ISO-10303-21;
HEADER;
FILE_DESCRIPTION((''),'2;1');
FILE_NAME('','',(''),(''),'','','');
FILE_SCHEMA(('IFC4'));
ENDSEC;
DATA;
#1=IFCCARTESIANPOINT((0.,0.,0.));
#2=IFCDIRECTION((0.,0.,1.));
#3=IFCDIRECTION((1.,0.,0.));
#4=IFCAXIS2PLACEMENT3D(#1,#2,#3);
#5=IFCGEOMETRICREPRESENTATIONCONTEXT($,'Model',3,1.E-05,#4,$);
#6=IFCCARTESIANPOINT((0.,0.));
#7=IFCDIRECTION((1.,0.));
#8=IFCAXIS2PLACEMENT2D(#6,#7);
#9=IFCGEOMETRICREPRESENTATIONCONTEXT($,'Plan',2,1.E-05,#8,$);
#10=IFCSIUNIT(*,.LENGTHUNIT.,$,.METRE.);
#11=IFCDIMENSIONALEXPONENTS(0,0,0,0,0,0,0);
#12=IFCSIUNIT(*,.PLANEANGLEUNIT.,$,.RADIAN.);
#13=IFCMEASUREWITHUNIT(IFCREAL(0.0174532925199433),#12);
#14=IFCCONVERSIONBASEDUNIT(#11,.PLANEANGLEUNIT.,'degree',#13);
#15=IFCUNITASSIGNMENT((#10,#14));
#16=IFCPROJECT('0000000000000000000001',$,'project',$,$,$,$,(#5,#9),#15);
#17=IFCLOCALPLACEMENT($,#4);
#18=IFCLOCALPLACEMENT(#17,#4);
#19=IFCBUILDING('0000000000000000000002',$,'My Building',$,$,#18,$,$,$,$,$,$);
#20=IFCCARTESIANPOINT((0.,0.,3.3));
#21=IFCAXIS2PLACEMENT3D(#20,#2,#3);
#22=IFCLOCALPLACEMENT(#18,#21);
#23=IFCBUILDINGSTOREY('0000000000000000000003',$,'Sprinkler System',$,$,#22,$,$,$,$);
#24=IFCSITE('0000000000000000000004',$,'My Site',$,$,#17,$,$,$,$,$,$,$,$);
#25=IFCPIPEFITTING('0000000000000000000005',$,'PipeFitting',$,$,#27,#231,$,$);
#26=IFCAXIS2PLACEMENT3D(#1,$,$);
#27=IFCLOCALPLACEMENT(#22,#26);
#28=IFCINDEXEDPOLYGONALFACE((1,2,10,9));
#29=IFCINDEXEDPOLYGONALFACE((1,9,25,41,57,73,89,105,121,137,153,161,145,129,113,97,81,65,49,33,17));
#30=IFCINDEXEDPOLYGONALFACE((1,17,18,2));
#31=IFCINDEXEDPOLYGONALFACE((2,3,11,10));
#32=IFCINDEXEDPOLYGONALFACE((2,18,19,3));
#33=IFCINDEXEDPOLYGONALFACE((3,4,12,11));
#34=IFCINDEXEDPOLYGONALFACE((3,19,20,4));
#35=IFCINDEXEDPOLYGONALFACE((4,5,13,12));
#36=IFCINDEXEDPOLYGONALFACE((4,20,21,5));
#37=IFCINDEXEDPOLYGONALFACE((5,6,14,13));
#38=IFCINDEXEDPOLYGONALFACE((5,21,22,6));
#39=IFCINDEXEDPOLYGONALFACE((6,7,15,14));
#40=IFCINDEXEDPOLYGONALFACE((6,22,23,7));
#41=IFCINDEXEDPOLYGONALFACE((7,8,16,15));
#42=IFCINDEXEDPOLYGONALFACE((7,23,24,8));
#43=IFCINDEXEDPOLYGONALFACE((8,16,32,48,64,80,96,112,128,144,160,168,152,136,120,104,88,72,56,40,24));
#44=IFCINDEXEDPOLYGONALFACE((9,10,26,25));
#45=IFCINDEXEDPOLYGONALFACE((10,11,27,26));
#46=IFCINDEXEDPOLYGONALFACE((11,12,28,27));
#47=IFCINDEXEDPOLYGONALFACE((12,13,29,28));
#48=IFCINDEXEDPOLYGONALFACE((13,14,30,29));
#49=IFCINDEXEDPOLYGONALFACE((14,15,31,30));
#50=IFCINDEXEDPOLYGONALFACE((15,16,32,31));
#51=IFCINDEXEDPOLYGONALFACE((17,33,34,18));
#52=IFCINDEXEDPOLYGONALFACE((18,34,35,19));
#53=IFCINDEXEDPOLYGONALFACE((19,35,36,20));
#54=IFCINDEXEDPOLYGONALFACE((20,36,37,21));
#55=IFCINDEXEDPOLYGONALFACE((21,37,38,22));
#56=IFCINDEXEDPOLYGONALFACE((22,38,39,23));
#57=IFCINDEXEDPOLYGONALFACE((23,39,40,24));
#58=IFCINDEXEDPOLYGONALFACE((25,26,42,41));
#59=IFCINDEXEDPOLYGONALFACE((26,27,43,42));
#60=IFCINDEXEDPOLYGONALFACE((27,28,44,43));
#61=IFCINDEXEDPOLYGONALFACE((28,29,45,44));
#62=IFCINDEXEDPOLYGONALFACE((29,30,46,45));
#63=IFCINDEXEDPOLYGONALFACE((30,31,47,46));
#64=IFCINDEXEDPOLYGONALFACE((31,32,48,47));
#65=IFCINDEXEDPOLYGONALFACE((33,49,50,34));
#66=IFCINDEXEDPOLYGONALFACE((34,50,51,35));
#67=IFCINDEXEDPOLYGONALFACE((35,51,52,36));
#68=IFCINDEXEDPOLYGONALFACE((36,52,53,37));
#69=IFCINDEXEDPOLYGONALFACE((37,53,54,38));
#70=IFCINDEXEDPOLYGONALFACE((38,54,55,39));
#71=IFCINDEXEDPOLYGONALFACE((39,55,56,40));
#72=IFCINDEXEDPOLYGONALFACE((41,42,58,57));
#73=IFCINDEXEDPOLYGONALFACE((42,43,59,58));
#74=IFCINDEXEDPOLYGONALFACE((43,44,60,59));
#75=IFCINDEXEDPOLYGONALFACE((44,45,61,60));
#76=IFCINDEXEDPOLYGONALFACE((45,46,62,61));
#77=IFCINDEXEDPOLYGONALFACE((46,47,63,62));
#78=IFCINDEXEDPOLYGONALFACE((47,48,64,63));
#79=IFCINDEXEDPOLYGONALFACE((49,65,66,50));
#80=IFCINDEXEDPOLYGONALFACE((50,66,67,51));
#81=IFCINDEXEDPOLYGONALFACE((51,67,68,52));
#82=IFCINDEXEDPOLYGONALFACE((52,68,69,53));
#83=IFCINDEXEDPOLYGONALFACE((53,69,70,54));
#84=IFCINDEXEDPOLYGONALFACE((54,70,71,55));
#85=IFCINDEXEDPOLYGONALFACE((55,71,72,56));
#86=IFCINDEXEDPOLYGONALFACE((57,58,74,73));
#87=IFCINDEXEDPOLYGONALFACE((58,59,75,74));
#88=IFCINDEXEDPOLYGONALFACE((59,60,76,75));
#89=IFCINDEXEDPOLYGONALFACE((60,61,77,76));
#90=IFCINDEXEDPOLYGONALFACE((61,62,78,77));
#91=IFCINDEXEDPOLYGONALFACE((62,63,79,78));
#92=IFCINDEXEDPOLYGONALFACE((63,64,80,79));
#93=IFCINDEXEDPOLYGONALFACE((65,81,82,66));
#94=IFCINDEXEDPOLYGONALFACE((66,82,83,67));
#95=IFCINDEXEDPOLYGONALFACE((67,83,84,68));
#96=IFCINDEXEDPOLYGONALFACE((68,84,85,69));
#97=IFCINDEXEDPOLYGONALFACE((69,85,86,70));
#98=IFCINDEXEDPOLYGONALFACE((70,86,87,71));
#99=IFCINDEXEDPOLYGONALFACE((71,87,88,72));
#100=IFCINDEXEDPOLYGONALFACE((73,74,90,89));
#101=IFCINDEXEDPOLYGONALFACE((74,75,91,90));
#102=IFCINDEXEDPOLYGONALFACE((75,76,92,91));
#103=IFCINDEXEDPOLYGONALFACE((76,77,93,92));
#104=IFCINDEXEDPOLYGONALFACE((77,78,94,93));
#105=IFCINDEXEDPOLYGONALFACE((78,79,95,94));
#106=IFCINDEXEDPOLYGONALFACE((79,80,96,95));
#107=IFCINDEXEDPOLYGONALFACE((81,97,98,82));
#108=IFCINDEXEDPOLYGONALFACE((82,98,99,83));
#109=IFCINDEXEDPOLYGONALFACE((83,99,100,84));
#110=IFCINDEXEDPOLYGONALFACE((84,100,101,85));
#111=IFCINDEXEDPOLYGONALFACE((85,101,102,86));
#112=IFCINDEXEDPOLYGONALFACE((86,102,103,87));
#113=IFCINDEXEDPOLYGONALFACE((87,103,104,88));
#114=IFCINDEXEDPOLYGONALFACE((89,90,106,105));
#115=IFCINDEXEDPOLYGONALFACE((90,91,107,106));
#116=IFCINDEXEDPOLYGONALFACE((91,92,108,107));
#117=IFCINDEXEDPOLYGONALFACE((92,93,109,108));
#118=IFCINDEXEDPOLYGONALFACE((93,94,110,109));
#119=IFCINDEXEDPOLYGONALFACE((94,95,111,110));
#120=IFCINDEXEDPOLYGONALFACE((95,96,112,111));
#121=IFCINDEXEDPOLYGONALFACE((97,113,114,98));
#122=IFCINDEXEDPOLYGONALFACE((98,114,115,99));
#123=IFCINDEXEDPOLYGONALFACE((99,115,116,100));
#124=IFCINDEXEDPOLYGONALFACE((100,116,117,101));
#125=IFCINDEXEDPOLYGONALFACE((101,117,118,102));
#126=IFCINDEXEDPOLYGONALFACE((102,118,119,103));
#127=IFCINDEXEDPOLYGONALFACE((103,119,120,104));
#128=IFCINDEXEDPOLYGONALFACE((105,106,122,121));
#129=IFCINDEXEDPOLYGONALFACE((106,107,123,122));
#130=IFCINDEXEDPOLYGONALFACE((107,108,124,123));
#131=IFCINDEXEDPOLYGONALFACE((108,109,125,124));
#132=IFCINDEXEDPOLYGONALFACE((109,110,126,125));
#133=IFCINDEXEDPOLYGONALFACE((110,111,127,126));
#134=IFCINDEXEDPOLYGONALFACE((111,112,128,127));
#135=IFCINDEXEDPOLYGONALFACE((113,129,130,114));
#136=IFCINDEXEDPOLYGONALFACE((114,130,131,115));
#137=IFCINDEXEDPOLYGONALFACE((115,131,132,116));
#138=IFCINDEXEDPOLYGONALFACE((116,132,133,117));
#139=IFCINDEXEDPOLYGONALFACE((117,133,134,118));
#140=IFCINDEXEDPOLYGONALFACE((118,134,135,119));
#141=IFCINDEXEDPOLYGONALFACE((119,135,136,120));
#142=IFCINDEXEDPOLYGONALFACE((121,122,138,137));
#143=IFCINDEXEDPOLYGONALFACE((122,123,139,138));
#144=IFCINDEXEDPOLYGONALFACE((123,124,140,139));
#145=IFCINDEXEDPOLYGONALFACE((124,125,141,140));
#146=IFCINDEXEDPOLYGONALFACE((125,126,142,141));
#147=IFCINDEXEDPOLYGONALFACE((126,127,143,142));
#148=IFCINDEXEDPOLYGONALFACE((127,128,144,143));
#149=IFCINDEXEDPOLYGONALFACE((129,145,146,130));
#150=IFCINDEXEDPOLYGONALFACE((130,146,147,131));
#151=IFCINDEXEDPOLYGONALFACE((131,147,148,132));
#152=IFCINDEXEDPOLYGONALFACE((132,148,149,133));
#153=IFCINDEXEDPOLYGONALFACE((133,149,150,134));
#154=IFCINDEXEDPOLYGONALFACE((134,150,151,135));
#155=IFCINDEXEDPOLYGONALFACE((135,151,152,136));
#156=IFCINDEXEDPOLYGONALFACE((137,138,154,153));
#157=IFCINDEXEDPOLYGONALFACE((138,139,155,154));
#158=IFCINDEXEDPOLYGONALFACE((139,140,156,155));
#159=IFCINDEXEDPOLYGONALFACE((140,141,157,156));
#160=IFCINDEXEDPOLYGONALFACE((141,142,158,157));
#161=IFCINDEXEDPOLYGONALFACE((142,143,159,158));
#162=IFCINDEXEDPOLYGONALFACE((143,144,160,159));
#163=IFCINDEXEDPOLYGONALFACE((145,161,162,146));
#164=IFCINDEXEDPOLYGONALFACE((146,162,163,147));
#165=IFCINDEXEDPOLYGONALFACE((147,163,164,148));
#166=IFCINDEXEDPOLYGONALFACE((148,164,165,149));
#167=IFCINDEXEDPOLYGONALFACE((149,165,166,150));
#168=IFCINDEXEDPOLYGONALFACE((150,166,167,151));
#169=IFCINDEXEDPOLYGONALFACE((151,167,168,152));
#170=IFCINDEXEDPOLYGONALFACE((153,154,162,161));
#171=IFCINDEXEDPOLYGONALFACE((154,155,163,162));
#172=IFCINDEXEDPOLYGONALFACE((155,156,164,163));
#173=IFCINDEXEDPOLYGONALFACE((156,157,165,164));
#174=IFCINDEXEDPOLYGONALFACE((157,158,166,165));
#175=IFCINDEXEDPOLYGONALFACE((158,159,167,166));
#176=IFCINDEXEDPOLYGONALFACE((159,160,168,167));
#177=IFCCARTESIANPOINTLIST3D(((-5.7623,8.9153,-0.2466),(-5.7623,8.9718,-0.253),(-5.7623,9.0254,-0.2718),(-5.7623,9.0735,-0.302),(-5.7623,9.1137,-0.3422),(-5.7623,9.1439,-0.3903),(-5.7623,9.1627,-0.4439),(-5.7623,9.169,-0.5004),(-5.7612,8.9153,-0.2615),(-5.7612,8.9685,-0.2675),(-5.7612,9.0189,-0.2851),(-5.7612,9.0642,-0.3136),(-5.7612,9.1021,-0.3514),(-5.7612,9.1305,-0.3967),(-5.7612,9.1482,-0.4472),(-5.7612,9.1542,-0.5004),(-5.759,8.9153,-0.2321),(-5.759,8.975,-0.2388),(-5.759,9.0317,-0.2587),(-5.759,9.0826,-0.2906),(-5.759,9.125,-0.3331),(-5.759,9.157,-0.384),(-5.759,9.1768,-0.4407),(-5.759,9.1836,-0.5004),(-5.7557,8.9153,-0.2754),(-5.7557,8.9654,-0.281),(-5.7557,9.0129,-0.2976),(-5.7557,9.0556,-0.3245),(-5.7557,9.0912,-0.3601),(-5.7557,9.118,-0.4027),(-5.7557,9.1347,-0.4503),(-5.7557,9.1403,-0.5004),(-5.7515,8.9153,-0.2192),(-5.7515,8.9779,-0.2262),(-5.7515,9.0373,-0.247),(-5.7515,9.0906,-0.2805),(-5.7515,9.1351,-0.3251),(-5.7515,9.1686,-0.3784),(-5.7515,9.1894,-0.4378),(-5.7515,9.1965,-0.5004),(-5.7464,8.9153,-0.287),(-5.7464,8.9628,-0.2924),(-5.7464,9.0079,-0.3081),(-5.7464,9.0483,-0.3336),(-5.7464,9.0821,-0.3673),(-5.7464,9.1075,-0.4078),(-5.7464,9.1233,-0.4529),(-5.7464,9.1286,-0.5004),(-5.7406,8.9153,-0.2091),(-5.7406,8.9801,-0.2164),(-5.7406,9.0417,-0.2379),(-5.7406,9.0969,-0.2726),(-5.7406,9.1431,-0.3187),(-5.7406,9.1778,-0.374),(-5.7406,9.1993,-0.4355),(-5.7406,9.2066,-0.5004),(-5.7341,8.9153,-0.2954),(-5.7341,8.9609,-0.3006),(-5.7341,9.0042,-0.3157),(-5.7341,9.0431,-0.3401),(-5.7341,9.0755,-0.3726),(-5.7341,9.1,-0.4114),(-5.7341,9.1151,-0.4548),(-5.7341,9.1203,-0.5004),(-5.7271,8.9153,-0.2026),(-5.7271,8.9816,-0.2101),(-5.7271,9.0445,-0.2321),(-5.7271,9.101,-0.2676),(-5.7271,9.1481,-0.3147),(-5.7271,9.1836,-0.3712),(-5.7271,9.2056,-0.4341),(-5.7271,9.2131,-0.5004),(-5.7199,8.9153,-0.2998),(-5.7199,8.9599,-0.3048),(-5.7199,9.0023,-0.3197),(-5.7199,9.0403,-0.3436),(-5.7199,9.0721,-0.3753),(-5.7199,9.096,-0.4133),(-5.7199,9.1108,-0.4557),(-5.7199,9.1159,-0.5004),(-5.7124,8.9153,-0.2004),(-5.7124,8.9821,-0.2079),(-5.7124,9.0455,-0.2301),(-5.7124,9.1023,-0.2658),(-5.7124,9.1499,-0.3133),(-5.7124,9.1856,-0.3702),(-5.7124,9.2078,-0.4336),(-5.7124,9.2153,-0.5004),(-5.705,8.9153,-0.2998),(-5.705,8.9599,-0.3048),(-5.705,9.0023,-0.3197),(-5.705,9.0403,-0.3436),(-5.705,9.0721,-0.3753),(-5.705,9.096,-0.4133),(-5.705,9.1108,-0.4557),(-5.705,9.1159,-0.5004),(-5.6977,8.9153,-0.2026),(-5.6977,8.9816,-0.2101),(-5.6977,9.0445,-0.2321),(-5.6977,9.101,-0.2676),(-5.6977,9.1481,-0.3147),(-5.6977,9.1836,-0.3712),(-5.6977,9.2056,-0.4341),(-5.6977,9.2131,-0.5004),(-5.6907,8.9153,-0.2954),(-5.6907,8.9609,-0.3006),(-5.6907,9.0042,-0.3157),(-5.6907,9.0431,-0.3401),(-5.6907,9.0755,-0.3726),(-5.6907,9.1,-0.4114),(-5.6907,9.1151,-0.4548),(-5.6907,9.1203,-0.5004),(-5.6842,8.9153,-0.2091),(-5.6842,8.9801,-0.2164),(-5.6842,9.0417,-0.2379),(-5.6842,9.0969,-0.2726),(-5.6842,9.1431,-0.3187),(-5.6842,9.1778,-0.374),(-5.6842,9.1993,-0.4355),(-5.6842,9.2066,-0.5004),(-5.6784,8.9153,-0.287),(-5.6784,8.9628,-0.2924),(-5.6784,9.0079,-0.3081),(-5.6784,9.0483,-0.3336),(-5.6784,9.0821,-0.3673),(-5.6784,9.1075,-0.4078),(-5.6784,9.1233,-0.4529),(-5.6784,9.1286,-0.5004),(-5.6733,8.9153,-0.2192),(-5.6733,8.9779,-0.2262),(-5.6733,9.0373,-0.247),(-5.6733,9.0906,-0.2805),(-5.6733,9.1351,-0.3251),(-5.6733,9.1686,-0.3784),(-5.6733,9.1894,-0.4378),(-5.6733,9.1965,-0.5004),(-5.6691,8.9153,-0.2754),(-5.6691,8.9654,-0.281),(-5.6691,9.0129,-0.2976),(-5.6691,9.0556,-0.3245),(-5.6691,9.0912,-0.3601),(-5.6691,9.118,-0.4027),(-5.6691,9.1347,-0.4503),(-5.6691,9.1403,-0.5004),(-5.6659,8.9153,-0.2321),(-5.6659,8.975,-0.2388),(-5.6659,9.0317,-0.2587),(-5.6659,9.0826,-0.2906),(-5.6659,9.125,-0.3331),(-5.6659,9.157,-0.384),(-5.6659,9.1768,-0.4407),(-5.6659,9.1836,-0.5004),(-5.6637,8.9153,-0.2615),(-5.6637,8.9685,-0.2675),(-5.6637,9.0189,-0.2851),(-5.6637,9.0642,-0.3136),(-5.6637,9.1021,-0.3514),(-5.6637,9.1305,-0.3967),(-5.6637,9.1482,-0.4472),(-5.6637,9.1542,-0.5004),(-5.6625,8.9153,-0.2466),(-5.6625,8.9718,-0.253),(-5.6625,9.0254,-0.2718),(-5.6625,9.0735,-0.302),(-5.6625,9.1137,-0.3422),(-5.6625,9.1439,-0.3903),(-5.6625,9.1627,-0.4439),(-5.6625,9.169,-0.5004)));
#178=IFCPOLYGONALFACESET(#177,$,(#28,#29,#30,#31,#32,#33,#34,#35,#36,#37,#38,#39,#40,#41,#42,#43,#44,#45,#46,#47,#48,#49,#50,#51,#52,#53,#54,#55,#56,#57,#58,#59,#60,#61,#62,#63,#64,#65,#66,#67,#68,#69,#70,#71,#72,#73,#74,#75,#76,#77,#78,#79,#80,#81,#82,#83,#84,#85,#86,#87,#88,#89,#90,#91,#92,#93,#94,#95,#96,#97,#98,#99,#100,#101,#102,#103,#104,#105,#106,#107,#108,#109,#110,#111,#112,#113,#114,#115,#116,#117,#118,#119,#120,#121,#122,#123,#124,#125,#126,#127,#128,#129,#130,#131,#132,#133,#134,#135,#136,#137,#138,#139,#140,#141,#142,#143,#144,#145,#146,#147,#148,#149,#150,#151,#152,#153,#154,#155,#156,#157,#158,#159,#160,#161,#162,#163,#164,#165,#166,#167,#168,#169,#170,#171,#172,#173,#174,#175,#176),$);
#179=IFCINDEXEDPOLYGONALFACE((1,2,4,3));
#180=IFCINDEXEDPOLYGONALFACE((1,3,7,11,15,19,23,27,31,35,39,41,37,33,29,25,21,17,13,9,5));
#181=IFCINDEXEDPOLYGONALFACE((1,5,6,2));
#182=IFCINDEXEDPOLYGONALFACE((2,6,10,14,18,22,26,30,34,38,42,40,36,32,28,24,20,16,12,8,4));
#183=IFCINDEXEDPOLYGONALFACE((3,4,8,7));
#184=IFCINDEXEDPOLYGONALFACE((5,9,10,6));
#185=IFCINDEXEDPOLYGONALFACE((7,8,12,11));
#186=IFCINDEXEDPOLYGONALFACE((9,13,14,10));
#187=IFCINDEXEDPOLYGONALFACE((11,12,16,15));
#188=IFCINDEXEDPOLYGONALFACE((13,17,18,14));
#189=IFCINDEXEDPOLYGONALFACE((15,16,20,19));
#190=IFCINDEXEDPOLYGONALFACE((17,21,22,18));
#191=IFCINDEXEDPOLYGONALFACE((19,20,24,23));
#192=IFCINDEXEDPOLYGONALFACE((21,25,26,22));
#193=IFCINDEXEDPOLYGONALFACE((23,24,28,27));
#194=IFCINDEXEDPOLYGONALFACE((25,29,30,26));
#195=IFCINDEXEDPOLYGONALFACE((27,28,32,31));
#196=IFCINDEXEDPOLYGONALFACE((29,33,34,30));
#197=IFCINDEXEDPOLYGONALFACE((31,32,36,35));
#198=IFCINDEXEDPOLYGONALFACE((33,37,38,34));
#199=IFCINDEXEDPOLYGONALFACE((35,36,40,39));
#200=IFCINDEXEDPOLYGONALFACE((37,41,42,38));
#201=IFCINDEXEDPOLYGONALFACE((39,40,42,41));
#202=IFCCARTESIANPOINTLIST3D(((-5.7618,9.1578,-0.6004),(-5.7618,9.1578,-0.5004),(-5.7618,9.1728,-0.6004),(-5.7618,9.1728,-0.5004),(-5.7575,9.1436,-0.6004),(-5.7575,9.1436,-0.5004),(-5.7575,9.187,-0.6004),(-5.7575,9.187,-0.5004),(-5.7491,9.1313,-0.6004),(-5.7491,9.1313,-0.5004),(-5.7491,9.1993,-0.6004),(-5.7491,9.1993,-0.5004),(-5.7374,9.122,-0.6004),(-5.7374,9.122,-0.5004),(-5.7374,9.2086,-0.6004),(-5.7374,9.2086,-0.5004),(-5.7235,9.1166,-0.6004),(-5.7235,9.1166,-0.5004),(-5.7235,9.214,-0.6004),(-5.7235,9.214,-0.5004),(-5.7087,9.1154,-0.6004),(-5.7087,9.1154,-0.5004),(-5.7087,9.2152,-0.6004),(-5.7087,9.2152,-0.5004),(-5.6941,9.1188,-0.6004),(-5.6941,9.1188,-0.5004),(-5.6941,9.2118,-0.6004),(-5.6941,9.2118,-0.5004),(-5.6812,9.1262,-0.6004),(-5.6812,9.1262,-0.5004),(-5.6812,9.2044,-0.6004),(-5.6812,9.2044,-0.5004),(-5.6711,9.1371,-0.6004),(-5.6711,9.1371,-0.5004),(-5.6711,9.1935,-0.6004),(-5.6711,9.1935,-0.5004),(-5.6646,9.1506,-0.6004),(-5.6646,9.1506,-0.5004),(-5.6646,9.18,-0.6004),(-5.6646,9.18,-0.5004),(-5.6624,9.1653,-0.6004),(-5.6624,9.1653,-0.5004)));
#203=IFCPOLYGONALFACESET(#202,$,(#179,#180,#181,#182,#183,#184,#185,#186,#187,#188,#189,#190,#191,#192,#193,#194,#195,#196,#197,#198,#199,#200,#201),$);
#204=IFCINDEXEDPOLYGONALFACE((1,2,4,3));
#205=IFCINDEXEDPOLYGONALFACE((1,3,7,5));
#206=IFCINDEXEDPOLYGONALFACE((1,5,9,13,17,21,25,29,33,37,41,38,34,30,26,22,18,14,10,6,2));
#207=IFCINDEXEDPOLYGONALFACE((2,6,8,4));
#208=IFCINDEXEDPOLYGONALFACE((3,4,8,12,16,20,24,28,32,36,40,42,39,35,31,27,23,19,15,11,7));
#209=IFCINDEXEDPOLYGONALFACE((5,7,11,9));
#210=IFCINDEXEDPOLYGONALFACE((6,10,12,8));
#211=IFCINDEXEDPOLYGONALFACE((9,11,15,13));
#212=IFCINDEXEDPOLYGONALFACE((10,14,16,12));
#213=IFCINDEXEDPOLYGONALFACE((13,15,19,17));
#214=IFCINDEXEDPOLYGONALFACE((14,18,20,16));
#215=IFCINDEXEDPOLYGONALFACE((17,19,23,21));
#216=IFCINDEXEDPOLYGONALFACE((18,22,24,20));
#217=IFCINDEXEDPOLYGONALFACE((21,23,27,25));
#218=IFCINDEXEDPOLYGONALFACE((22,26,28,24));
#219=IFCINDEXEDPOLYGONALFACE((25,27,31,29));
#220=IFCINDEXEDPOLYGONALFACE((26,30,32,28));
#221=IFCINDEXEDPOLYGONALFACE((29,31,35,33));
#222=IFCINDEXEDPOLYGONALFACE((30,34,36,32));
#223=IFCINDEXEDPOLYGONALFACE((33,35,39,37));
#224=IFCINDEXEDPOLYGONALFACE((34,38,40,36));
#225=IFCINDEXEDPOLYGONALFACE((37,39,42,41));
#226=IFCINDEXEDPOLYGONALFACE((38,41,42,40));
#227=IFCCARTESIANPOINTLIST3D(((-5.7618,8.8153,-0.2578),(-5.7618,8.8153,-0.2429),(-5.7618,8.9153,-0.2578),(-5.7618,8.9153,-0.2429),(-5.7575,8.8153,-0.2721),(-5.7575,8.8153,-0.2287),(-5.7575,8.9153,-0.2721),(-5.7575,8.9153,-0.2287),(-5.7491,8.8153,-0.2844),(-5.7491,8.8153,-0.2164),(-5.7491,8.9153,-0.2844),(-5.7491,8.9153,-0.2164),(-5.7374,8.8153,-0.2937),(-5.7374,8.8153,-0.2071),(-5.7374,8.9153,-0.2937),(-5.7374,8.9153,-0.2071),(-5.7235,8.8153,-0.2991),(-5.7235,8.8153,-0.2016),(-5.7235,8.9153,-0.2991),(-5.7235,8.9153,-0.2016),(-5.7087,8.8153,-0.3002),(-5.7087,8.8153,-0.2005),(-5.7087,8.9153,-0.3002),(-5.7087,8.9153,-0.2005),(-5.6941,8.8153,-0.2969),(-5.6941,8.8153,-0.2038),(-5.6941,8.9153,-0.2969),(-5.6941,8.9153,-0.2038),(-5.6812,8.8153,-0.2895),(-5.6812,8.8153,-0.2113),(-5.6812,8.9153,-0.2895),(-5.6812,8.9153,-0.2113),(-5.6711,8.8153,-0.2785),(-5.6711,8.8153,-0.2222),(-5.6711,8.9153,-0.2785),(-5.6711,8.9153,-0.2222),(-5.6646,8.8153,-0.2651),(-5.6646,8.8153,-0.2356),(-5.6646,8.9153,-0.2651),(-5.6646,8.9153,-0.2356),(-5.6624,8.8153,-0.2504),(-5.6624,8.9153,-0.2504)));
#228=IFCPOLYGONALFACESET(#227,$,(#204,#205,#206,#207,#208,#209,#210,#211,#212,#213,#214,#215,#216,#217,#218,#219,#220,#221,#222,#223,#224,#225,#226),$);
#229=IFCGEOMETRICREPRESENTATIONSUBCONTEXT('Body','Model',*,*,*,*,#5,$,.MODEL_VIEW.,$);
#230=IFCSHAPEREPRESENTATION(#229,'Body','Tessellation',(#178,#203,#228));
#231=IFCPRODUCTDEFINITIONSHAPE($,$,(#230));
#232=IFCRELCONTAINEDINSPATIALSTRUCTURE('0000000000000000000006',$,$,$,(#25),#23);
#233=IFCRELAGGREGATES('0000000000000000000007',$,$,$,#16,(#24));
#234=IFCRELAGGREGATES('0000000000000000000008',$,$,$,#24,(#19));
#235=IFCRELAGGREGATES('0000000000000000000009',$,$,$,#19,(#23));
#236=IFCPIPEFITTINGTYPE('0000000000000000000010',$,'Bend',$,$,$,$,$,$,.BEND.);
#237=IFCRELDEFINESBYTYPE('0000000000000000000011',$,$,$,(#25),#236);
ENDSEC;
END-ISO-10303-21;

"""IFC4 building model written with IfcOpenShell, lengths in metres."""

from ifc_helpers import new_model, entity, si_unit, converted_unit, frame, origin_with_axes, origin_2d_with_axis, place, context, subcontext, project, spatial, circle, extrude, source, transform, mapped, type_object, type_shapes, element, save


model = new_model("IFC4")

# Units and contexts
model_context = context("Model", 3, precision=1e-05, world=origin_with_axes())
plan_context = context("Plan", 2, precision=1e-05, world=origin_2d_with_axis())
body_context = subcontext(model_context, "Body", "Model", "MODEL_VIEW")
ifc_project = project(units=[si_unit("LENGTHUNIT", "METRE"), converted_unit("PLANEANGLEUNIT", "degree", entity("IfcReal", 0.0174532925199433), si_unit("PLANEANGLEUNIT", "RADIAN"), dimensions=[0, 0, 0, 0, 0, 0, 0])], contexts=[model_context, plan_context])

# Site, building, storey
site_placement = place(None, origin_with_axes())
site = spatial("IfcSite", under=ifc_project, at=site_placement, Name="My Site")
building_placement = place(site_placement, origin_with_axes())
building = spatial("IfcBuilding", under=site, at=building_placement, Name="My Building")
storey_placement = place(building_placement, frame((0.0, 0.0, 3.3), z_axis=(0.0, 0.0, 1.0), x_axis=(1.0, 0.0, 0.0)))
storey = spatial("IfcBuildingStorey", under=building, at=storey_placement, Name="Sprinkler System")

# Pipe fitting
pipe_fitting_type_1 = type_object("IfcPipeFittingType", Name="Bend", PredefinedType="BEND")
shared_shape_1 = source(origin_with_axes(), body_context, "Body", "SolidModel", [
    entity("IfcSweptDiskSolid", entity("IfcIndexedPolyCurve", entity("IfcCartesianPointList3D", [[0.0, 0.0, -0.1], [0.0, 0.0732, -0.2768], [0.0, 0.25, -0.35]]), [entity("IfcArcIndex", [1, 2, 3])]), 0.05),
    extrude(circle(Radius=0.05), origin_with_axes(), (0.0, 0.0, -1.0), 0.1),
    extrude(circle(Radius=0.05), frame((0.0, 0.25, -0.35), z_axis=(0.0, 1.0, 0.0), x_axis=(1.0, 0.0, 0.0)), (0.0, 0.0, 1.0), 0.1),
])
type_shapes(pipe_fitting_type_1, [shared_shape_1])
for number, where, z_axis, x_axis, name in (
    (1, (-5.7124, 9.1653, -0.6004), (0.0, 0.0, -1.0), (1.0, 0.0, 0.0), "PipeFitting"),
):
    element("IfcPipeFitting", number, at=place(storey_placement, frame(where, z_axis=z_axis, x_axis=x_axis)), inside=storey, type_object=pipe_fitting_type_1, Name=name, context=body_context, shape_type="MappedRepresentation", body=[
        mapped(shared_shape_1, transform((0.0, 0.0, 0.0), x_axis=(1.0, 0.0, 0.0), y_axis=(0.0, 1.0, 0.0), z_axis=(0.0, 0.0, 1.0), scale=1.0)),
    ])

save(model, "model.ifc")
